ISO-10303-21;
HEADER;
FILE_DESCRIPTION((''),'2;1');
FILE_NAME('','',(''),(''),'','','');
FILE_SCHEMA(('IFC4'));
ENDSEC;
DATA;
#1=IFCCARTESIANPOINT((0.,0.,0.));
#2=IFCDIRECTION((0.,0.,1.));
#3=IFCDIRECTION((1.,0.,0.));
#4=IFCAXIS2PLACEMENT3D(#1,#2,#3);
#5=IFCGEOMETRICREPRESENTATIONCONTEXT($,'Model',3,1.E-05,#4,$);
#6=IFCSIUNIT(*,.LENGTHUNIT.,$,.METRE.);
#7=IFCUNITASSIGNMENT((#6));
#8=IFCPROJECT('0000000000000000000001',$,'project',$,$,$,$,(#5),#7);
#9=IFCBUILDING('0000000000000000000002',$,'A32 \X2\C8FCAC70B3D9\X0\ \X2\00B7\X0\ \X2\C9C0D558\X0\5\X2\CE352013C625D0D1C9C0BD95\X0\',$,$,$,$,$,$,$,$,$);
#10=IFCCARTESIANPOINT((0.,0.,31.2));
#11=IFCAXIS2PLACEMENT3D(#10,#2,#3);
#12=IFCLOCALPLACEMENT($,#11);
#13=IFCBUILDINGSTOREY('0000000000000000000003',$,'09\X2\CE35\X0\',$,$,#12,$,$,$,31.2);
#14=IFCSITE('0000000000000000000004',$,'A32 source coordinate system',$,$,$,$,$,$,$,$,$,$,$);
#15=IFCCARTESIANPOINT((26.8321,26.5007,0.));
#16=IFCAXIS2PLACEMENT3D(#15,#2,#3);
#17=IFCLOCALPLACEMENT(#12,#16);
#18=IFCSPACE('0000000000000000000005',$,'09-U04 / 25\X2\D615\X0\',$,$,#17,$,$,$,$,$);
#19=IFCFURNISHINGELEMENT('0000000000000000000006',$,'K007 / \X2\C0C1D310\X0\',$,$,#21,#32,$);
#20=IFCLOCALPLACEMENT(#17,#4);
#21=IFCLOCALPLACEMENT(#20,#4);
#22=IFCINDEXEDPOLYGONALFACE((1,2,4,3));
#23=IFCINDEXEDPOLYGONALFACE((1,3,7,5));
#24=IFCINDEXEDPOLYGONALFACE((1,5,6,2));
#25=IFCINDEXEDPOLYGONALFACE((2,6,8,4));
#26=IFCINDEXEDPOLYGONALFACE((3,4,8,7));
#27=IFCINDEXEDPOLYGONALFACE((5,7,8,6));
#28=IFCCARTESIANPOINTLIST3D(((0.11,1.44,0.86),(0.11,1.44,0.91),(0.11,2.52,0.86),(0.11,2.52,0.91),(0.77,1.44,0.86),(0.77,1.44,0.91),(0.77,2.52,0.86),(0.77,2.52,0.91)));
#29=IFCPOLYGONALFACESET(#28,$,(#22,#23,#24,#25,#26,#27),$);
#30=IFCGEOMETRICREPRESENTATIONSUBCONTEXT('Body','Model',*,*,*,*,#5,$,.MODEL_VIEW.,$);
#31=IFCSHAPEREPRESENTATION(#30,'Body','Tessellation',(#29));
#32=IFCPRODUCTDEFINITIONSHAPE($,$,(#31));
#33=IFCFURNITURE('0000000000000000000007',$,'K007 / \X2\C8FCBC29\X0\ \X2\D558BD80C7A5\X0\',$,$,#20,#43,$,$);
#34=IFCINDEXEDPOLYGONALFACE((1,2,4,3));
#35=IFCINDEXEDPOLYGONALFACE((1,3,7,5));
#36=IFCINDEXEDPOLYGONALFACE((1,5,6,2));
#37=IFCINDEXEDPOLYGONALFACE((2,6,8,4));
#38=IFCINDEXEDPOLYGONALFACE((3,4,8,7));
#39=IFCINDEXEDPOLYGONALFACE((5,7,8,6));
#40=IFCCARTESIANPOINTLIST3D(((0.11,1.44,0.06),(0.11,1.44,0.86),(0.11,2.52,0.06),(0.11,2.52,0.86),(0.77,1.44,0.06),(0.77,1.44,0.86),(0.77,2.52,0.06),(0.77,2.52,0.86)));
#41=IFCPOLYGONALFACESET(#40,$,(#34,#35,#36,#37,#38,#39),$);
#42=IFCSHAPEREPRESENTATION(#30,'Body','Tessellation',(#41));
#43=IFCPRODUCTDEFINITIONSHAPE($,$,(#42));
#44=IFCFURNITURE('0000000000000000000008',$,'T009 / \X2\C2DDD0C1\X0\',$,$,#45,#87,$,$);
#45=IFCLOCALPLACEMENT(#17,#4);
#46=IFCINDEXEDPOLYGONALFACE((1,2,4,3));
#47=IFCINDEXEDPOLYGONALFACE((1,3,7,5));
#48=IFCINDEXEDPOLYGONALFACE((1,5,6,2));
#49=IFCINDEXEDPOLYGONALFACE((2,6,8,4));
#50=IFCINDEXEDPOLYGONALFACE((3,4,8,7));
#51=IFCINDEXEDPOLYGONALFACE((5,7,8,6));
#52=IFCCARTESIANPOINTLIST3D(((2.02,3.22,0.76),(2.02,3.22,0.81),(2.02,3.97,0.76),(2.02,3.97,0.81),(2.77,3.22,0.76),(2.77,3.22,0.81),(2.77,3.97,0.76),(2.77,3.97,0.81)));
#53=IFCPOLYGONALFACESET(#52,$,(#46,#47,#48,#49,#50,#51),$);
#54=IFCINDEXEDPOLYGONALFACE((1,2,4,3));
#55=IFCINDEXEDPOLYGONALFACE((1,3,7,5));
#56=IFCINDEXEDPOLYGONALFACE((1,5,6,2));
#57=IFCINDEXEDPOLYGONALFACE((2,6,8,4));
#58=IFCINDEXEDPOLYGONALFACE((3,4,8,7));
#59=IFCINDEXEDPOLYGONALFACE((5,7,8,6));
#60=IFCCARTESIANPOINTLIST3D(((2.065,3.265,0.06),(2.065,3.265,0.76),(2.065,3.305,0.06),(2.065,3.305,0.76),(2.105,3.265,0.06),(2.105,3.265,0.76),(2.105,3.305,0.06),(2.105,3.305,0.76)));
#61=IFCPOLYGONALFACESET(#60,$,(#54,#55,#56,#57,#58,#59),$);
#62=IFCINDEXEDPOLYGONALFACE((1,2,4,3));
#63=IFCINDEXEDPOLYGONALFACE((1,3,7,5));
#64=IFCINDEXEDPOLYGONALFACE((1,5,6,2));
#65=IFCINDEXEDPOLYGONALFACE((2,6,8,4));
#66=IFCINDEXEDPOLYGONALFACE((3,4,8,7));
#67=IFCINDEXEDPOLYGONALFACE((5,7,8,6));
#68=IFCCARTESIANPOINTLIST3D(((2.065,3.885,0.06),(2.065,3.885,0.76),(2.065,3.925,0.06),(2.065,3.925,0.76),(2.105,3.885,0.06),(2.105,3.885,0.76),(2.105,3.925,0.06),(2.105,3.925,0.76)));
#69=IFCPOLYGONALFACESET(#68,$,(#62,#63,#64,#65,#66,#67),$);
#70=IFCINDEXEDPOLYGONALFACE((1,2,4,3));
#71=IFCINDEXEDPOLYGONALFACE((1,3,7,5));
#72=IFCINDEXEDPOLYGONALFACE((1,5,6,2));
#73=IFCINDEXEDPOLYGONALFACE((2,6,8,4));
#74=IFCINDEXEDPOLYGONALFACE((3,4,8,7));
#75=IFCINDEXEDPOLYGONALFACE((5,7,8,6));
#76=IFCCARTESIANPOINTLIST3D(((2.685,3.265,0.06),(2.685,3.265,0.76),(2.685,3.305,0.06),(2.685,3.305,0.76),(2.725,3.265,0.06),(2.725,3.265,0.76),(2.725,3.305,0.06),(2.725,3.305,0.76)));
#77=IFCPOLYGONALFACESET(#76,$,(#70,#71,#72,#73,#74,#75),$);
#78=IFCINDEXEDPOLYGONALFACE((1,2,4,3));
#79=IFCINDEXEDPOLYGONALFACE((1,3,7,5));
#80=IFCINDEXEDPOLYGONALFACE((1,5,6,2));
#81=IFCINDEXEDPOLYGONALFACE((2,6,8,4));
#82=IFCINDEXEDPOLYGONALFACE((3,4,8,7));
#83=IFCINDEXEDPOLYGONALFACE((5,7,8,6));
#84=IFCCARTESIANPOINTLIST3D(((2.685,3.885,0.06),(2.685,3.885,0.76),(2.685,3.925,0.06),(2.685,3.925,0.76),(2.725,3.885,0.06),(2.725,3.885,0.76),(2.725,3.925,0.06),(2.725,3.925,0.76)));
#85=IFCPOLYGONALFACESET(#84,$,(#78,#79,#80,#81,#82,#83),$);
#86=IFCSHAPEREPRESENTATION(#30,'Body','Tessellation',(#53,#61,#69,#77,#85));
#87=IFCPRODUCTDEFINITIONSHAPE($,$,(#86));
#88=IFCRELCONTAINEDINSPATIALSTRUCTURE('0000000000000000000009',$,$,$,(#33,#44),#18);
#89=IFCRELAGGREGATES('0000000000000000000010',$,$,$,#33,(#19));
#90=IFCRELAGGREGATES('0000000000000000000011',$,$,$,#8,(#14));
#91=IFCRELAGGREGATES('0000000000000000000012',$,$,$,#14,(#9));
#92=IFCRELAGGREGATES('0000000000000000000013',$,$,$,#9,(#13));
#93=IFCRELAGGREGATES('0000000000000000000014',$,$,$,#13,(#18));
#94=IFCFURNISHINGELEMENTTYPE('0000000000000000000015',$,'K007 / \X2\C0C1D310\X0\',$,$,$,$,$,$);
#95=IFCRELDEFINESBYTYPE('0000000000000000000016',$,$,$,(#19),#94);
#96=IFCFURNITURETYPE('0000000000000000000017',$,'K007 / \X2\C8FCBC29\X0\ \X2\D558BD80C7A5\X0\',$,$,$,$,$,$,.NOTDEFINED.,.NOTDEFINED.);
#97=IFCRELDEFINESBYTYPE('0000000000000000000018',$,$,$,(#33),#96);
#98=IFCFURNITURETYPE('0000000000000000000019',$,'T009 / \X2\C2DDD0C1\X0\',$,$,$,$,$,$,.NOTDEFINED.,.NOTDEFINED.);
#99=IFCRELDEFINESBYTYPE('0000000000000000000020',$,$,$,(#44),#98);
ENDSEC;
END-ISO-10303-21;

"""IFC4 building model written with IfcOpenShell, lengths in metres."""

from ifc_helpers import new_model, si_unit, frame, origin, origin_with_axes, place, context, subcontext, project, spatial, polyline, outline, extrude, source, transform, mapped, type_object, type_shapes, element, aggregate, save


model = new_model("IFC4")

# Units and contexts
model_context = context("Model", 3, precision=1e-05, world=origin_with_axes())
body_context = subcontext(model_context, "Body", "Model", "MODEL_VIEW")
ifc_project = project(units=[si_unit("LENGTHUNIT", "METRE")], contexts=[model_context])

# Site, building, storey
site = spatial("IfcSite", under=ifc_project, Name="A32 source coordinate system")
building = spatial("IfcBuilding", under=site, Name="A32 주거동 · 지하5층–옥탑지붕")
storey_placement = place(None, frame((0.0, 0.0, 31.2), z_axis=(0.0, 0.0, 1.0), x_axis=(1.0, 0.0, 0.0)))
storey = spatial("IfcBuildingStorey", under=building, at=storey_placement, Name="09층", Elevation=31.2)

# Shared definitions
space_1_placement = place(storey_placement, frame((26.8321, 26.5007, 0.0), z_axis=(0.0, 0.0, 1.0), x_axis=(1.0, 0.0, 0.0)))
space_1 = spatial("IfcSpace", under=storey, at=space_1_placement, Name="09-U04 / 25형")

# Furnishing element
furnishing_element_type_1 = type_object("IfcFurnishingElementType", Name="K007 / 상판")
shared_shape_1 = source(origin(), body_context, "Body", "SweptSolid", [
    extrude(outline(polyline([(0.77, 2.52), (0.77, 1.44), (0.11, 1.44), (0.11, 2.52), (0.77, 2.52)])), frame((0.0, 0.0, 0.86)), (0.0, 0.0, 1.0), 0.05),
])
type_shapes(furnishing_element_type_1, [shared_shape_1])
furniture_1_placement = place(space_1_placement, origin_with_axes())
furnishing_1_placement = place(furniture_1_placement, origin_with_axes())
furnishing_1 = element("IfcFurnishingElement", 1, at=furnishing_1_placement, type_object=furnishing_element_type_1, Name="K007 / 상판", context=body_context, shape_type="MappedRepresentation", body=[
    mapped(shared_shape_1, transform((0.0, 0.0, 0.0), scale=1.0)),
])

# Furniture
furniture_type_1 = type_object("IfcFurnitureType", Name="K007 / 주방 하부장", AssemblyPlace="NOTDEFINED", PredefinedType="NOTDEFINED")
shared_shape_2 = source(origin(), body_context, "Body", "SweptSolid", [
    extrude(outline(polyline([(0.11, 2.52), (0.77, 2.52), (0.77, 1.44), (0.11, 1.44), (0.11, 2.52)])), frame((0.0, 0.0, 0.06)), (0.0, 0.0, 1.0), 0.8),
])
type_shapes(furniture_type_1, [shared_shape_2])
furniture_1 = element("IfcFurniture", 2, at=furniture_1_placement, inside=space_1, type_object=furniture_type_1, Name="K007 / 주방 하부장", context=body_context, shape_type="MappedRepresentation", body=[
    mapped(shared_shape_2, transform((0.0, 0.0, 0.0), scale=1.0)),
])
aggregate(furniture_1, [furnishing_1])
furniture_type_2 = type_object("IfcFurnitureType", Name="T009 / 식탁", AssemblyPlace="NOTDEFINED", PredefinedType="NOTDEFINED")
shared_shape_3 = source(origin(), body_context, "Body", "SweptSolid", [
    extrude(outline(polyline([(2.77, 3.22), (2.02, 3.22), (2.02, 3.97), (2.77, 3.97), (2.77, 3.22)])), frame((0.0, 0.0, 0.76)), (0.0, 0.0, 1.0), 0.05),
    extrude(outline(polyline([(2.065, 3.265), (2.065, 3.305), (2.105, 3.305), (2.105, 3.265), (2.065, 3.265)])), frame((0.0, 0.0, 0.06)), (0.0, 0.0, 1.0), 0.7),
    extrude(outline(polyline([(2.065, 3.885), (2.065, 3.925), (2.105, 3.925), (2.105, 3.885), (2.065, 3.885)])), frame((0.0, 0.0, 0.06)), (0.0, 0.0, 1.0), 0.7),
    extrude(outline(polyline([(2.685, 3.265), (2.685, 3.305), (2.725, 3.305), (2.725, 3.265), (2.685, 3.265)])), frame((0.0, 0.0, 0.06)), (0.0, 0.0, 1.0), 0.7),
    extrude(outline(polyline([(2.685, 3.885), (2.685, 3.925), (2.725, 3.925), (2.725, 3.885), (2.685, 3.885)])), frame((0.0, 0.0, 0.06)), (0.0, 0.0, 1.0), 0.7),
])
type_shapes(furniture_type_2, [shared_shape_3])
furniture_2_placement = place(space_1_placement, origin_with_axes())
element("IfcFurniture", 3, at=furniture_2_placement, inside=space_1, type_object=furniture_type_2, Name="T009 / 식탁", context=body_context, shape_type="MappedRepresentation", body=[
    mapped(shared_shape_3, transform((0.0, 0.0, 0.0), scale=1.0)),
])

save(model, "model.ifc")
